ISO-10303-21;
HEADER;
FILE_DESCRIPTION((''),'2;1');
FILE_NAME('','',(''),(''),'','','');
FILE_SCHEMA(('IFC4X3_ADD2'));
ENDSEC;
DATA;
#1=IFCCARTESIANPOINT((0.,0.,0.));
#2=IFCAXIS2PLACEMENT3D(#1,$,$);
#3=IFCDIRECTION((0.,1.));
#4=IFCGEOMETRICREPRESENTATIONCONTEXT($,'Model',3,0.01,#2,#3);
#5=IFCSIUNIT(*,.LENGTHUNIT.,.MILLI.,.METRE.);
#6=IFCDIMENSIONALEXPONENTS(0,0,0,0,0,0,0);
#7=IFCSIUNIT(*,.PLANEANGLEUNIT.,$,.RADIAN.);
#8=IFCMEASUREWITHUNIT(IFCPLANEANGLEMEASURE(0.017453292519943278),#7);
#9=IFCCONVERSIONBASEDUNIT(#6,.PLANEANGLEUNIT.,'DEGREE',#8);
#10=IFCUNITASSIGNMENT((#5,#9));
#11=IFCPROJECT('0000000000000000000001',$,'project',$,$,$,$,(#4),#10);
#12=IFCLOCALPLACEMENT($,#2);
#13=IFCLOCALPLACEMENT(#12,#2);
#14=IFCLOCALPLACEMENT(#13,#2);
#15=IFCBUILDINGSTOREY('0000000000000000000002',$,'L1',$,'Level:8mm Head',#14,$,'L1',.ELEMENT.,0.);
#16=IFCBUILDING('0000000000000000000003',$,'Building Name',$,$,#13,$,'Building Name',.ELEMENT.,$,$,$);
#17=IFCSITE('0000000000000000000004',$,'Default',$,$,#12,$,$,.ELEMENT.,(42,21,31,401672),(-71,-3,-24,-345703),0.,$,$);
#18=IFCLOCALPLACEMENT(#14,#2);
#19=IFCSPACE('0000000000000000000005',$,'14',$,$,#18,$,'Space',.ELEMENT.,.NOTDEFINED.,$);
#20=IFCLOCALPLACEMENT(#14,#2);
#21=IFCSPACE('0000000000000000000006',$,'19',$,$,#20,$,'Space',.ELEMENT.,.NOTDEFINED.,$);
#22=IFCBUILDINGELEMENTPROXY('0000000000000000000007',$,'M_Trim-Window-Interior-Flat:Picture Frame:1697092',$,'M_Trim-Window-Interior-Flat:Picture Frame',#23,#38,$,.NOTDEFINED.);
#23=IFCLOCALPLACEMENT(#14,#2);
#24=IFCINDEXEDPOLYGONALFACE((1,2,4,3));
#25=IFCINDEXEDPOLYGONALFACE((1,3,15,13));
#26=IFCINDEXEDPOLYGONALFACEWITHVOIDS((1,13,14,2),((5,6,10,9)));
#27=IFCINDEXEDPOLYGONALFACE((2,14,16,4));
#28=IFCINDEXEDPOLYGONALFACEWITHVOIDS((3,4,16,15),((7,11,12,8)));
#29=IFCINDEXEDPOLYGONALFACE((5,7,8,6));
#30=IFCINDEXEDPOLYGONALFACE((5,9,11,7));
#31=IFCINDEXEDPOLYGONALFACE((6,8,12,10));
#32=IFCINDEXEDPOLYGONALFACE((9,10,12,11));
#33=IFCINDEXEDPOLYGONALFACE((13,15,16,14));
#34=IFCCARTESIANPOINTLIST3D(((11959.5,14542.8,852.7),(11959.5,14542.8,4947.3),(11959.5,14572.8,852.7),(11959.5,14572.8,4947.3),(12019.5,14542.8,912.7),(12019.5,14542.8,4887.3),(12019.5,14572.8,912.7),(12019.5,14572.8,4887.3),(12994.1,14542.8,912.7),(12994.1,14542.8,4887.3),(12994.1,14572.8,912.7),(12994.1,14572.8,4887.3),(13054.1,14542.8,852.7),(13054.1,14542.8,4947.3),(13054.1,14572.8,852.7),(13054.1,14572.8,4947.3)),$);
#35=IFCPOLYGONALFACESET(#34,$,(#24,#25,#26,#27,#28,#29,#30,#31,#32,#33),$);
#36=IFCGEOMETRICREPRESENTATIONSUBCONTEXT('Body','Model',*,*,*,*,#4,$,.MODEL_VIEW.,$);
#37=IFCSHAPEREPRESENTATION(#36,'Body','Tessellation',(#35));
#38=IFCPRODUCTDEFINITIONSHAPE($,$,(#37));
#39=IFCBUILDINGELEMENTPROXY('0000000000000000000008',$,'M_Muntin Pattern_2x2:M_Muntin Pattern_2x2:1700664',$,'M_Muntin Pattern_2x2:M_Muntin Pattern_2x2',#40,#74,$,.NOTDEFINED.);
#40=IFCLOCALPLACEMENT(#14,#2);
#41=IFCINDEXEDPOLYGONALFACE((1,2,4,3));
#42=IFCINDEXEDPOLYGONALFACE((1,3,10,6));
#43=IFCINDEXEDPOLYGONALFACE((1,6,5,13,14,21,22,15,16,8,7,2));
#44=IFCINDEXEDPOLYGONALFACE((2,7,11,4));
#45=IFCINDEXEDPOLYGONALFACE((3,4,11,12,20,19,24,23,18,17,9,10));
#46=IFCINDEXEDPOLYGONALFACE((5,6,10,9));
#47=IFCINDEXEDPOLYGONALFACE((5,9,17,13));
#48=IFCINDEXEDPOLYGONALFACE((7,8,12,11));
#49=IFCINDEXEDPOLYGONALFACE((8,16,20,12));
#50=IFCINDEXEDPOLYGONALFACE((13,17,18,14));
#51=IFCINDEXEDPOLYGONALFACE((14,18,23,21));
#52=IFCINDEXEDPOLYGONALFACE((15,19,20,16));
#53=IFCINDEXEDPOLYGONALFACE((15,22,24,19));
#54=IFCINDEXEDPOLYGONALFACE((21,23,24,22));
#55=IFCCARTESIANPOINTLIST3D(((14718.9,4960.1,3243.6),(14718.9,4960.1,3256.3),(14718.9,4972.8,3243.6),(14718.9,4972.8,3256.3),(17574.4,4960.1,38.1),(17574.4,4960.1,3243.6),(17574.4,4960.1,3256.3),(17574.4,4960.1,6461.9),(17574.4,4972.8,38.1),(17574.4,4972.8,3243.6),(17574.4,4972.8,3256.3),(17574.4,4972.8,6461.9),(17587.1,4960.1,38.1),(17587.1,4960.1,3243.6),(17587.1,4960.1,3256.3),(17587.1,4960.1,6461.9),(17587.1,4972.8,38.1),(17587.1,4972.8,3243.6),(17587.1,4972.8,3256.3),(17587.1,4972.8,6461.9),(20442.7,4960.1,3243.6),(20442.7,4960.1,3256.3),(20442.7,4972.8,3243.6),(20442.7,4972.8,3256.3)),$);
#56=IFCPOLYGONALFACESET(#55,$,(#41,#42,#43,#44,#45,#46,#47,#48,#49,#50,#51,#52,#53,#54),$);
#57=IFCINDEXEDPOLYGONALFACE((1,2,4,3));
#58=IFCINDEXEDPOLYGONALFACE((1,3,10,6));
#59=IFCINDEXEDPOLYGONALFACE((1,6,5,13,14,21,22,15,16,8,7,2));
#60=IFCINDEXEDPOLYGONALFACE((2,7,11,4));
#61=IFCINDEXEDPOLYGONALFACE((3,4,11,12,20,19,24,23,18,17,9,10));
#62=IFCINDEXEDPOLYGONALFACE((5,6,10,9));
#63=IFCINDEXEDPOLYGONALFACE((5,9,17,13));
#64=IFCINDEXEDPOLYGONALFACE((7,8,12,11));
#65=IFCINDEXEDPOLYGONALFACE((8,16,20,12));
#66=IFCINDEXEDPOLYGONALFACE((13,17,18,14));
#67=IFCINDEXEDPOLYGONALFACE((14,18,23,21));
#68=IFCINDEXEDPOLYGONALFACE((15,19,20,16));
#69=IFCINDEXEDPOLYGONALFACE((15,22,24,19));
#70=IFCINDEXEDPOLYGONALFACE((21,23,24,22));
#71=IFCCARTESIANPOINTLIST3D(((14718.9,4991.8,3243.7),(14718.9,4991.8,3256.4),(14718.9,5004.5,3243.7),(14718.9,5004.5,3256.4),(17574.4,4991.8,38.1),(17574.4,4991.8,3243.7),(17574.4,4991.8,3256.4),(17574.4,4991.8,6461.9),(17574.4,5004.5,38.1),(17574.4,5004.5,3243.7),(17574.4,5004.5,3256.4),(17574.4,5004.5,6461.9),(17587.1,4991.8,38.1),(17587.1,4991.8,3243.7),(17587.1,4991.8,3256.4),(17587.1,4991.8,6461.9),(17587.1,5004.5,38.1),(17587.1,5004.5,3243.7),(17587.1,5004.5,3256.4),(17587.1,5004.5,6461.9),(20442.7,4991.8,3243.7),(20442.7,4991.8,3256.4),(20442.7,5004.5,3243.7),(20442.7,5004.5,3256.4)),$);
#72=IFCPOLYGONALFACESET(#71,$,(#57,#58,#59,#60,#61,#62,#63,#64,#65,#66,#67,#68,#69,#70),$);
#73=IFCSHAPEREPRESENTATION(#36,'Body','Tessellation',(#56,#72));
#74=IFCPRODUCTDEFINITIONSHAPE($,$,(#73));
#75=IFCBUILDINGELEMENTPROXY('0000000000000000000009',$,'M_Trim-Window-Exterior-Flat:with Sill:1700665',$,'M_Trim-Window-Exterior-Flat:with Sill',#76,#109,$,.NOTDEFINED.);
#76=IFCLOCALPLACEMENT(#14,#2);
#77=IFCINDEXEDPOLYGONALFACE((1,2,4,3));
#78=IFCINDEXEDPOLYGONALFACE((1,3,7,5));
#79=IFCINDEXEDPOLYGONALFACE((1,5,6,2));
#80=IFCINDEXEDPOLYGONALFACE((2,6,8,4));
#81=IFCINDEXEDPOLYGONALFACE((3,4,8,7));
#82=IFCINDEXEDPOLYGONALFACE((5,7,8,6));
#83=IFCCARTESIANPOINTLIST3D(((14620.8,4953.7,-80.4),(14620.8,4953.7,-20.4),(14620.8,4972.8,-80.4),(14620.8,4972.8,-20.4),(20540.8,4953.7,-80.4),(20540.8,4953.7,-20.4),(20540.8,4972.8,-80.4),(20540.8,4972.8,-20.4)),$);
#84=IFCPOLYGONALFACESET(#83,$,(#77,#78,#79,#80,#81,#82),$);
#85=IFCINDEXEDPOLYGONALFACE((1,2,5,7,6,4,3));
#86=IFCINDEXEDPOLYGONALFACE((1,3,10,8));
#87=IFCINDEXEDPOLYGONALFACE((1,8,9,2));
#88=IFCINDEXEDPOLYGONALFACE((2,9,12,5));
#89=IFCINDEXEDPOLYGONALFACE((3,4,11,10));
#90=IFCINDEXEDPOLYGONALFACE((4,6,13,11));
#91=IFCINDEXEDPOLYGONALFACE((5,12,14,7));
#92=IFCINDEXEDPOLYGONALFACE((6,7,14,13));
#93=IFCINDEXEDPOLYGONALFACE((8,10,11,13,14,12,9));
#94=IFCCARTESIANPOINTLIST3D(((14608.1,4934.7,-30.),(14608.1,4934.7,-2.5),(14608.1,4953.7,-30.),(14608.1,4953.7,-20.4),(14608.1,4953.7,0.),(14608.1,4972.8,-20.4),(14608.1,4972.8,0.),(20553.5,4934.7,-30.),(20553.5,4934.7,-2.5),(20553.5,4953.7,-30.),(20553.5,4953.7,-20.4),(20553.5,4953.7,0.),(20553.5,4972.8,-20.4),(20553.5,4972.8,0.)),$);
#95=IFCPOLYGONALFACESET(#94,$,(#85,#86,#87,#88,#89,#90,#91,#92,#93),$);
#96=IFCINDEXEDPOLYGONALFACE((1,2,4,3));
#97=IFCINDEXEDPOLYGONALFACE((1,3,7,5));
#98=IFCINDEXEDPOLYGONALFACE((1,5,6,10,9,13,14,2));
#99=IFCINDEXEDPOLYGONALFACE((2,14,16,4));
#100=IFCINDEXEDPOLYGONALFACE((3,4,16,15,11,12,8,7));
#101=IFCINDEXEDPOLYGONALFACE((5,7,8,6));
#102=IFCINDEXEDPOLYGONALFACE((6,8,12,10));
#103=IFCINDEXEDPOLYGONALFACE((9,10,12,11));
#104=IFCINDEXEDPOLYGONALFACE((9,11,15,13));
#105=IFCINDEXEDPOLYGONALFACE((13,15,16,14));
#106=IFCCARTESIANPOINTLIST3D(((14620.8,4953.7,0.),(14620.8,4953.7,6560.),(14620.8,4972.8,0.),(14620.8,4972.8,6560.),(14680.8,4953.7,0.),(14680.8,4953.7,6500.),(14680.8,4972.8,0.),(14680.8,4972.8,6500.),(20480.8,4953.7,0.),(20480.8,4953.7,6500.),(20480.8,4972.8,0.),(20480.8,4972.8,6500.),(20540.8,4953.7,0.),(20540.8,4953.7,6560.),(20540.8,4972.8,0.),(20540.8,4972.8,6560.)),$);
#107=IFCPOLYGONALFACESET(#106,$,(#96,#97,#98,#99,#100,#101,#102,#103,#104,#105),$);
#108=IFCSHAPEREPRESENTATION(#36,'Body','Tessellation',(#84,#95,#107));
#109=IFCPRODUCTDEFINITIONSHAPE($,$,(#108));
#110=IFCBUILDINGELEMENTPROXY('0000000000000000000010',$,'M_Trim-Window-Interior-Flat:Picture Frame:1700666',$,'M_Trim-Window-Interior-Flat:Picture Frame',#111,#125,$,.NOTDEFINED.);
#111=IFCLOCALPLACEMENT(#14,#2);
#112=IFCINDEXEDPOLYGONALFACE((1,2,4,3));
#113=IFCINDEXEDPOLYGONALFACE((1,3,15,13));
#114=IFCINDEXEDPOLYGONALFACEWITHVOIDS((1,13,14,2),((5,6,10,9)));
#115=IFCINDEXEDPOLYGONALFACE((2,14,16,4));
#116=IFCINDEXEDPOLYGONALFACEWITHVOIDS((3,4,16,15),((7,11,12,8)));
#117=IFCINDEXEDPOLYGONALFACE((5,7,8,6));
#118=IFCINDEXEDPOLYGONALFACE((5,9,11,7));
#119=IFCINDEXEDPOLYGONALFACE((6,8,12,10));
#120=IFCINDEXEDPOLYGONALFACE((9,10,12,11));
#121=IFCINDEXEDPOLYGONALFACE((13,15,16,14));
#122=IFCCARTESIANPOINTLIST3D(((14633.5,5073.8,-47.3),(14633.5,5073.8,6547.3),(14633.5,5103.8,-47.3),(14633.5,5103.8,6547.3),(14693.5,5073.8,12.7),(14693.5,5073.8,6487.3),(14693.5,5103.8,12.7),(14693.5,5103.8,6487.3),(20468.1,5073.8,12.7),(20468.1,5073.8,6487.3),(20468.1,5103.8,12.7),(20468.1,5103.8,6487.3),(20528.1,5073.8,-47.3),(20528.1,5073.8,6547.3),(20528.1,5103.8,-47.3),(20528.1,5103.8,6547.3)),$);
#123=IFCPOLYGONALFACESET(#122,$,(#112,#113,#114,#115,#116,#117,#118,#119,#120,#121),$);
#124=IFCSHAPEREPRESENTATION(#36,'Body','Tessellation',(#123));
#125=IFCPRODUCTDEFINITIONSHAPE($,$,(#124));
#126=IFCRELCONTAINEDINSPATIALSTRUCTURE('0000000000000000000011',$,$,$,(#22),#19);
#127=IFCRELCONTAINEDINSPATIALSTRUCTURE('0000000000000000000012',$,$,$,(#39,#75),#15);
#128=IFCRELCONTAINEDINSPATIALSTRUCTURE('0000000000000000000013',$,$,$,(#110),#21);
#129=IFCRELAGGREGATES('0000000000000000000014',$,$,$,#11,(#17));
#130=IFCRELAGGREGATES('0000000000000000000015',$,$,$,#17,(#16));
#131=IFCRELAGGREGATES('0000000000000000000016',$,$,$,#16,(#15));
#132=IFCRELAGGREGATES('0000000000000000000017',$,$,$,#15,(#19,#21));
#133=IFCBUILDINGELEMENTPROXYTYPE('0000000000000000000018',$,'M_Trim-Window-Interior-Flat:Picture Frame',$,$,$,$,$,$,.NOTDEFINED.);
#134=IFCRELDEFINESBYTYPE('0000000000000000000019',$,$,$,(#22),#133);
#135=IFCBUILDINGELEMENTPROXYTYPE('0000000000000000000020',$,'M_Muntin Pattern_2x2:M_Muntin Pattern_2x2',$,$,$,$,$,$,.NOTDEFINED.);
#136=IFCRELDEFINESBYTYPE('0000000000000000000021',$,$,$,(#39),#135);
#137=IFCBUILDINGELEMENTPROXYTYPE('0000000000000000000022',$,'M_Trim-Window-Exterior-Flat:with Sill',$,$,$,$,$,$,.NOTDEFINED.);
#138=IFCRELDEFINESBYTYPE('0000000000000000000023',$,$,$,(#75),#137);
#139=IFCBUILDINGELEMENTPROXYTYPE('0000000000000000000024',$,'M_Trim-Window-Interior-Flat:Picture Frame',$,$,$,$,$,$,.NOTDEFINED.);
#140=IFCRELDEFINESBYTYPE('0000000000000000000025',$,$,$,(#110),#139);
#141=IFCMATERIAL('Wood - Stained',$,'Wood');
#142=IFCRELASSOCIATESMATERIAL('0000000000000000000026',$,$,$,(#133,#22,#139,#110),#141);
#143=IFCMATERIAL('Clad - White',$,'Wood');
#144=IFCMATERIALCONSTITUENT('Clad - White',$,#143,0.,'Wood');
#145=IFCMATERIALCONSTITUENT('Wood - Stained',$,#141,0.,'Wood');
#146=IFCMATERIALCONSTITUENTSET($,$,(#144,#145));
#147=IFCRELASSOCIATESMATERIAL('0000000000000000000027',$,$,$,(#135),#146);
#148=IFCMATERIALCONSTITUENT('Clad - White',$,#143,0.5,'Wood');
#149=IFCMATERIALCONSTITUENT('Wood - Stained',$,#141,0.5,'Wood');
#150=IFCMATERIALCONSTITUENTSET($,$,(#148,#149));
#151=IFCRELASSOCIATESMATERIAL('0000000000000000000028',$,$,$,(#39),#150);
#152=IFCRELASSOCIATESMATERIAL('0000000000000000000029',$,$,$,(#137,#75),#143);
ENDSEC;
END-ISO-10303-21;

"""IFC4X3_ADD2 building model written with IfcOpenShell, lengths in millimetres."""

from ifc_helpers import new_model, entity, si_unit, converted_unit, direction, frame, frame_2d, origin, place, context, subcontext, project, spatial, polyline, rectangle, outline, extrude, source, transform, mapped, material, constituent, constituent_set, type_object, type_shapes, element, save


model = new_model("IFC4X3_ADD2")

# Units and contexts
model_context = context("Model", 3, precision=0.01, world=origin(), true_north=direction((0.0, 1.0)))
body_context = subcontext(model_context, "Body", "Model", "MODEL_VIEW")
ifc_project = project(units=[si_unit("LENGTHUNIT", "METRE", prefix="MILLI"), converted_unit("PLANEANGLEUNIT", "DEGREE", entity("IfcPlaneAngleMeasure", 0.017453292519943278), si_unit("PLANEANGLEUNIT", "RADIAN"), dimensions=[0, 0, 0, 0, 0, 0, 0])], contexts=[model_context])

# Site, building, storey
site_placement = place(None, origin())
site = spatial("IfcSite", under=ifc_project, at=site_placement, Name="Default", CompositionType="ELEMENT", RefLatitude=(42, 21, 31, 401672), RefLongitude=(-71, -3, -24, -345703), RefElevation=0.0)
building_placement = place(site_placement, origin())
building = spatial("IfcBuilding", under=site, at=building_placement, Name="Building Name", LongName="Building Name", CompositionType="ELEMENT")
storey_placement = place(building_placement, origin())
storey = spatial("IfcBuildingStorey", under=building, at=storey_placement, Name="L1", ObjectType="Level:8mm Head", LongName="L1", CompositionType="ELEMENT", Elevation=0.0)

# Shared definitions
ifc_material_1 = material(Name="Clad - White", Category="Wood")
ifc_material_2 = material(Name="Wood - Stained", Category="Wood")

# Shared definitions
building_element_proxy_type_1 = type_object("IfcBuildingElementProxyType", Name="M_Trim-Window-Interior-Flat:Picture Frame", PredefinedType="NOTDEFINED", material=ifc_material_2)
shared_shape_1 = source(origin(), body_context, "Body", "SweptSolid", [
    extrude(outline(polyline([(-547.3, -2047.3), (547.3, -2047.3), (547.3, 2047.3), (-547.3, 2047.3), (-547.3, -2047.3)]), holes=[polyline([(-487.3, -1987.3), (-487.3, 1987.3), (487.3, 1987.3), (487.3, -1987.3), (-487.3, -1987.3)])]), frame((0.0, -2000.0, 0.0), z_axis=(0.0, 0.0, 1.0), x_axis=(-1.0, 0.0, 0.0)), (0.0, 0.0, 1.0), 30.0),
])
type_shapes(building_element_proxy_type_1, [shared_shape_1])

# Shared definitions
space_1_placement = place(storey_placement, origin())
space_1 = spatial("IfcSpace", under=storey, at=space_1_placement, Name="14", LongName="Space", CompositionType="ELEMENT", PredefinedType="NOTDEFINED")

# Building element proxies
proxy_1_placement = place(space_1_placement, frame((12506.8, 14572.8, 4900.0), z_axis=(0.0, -1.0, 0.0), x_axis=(1.0, 0.0, 0.0)))
element("IfcBuildingElementProxy", 1, at=proxy_1_placement, inside=space_1, type_object=building_element_proxy_type_1, material=ifc_material_2, Name="M_Trim-Window-Interior-Flat:Picture Frame:1697092", ObjectType="M_Trim-Window-Interior-Flat:Picture Frame", PredefinedType="NOTDEFINED", context=body_context, shape_type="MappedRepresentation", body=[
    mapped(shared_shape_1, transform((0.0, 0.0, 0.0), scale=1.0)),
])
ifc_constituent_1 = constituent(ifc_material_1, Name="Clad - White", Category="Wood", fraction=0.5)
ifc_constituent_2 = constituent(ifc_material_2, Name="Wood - Stained", Category="Wood", fraction=0.5)
ifc_constituent_set_1 = constituent_set(constituents=[ifc_constituent_1, ifc_constituent_2])
ifc_constituent_3 = constituent(ifc_material_1, Name="Clad - White", Category="Wood", fraction=0.0)
ifc_constituent_4 = constituent(ifc_material_2, Name="Wood - Stained", Category="Wood", fraction=0.0)
ifc_constituent_set_2 = constituent_set(constituents=[ifc_constituent_3, ifc_constituent_4])
building_element_proxy_type_2 = type_object("IfcBuildingElementProxyType", Name="M_Muntin Pattern_2x2:M_Muntin Pattern_2x2", PredefinedType="NOTDEFINED", material=ifc_constituent_set_2)
shared_shape_2 = source(origin(), body_context, "Body", "SweptSolid", [
    extrude(outline(polyline([(6.4, -6.4), (3211.9, -6.4), (3211.9, 6.3), (6.4, 6.3), (6.4, 2861.9), (-6.3, 2861.9), (-6.3, 6.3), (-3211.9, 6.3), (-3211.9, -6.4), (-6.3, -6.4), (-6.3, -2861.9), (6.4, -2861.9), (6.4, -6.4)])), frame((0.0, -22.2, 3211.9), z_axis=(0.0, 1.0, 0.0), x_axis=(0.0, 0.0, 1.0)), (0.0, 0.0, 1.0), 12.7),
    extrude(outline(polyline([(6.4, -6.4), (3211.9, -6.4), (3211.9, 6.3), (6.4, 6.3), (6.4, 2861.9), (-6.3, 2861.9), (-6.3, 6.3), (-3211.9, 6.3), (-3211.9, -6.4), (-6.3, -6.4), (-6.3, -2861.9), (6.4, -2861.9), (6.4, -6.4)])), frame((0.0, 9.5, 3211.9), z_axis=(0.0, 1.0, 0.0), x_axis=(0.0, 0.0, 1.0)), (0.0, 0.0, 1.0), 12.7),
])
type_shapes(building_element_proxy_type_2, [shared_shape_2])
proxy_2_placement = place(storey_placement, frame((17580.8, 4982.3, 38.1)))
element("IfcBuildingElementProxy", 2, at=proxy_2_placement, inside=storey, type_object=building_element_proxy_type_2, material=ifc_constituent_set_1, Name="M_Muntin Pattern_2x2:M_Muntin Pattern_2x2:1700664", ObjectType="M_Muntin Pattern_2x2:M_Muntin Pattern_2x2", PredefinedType="NOTDEFINED", context=body_context, shape_type="MappedRepresentation", body=[
    mapped(shared_shape_2, transform((0.0, 0.0, 0.0), scale=1.0)),
])
building_element_proxy_type_3 = type_object("IfcBuildingElementProxyType", Name="M_Trim-Window-Exterior-Flat:with Sill", PredefinedType="NOTDEFINED", material=ifc_material_1)
shared_shape_3 = source(origin(), body_context, "Body", "SweptSolid", [
    extrude(rectangle(XDim=5920.0, YDim=60.0, at=frame_2d((0.0, 0.0), x_axis=(1.0, 0.0))), frame((0.0, -6550.4, 0.0), z_axis=(0.0, 0.0, 1.0), x_axis=(-1.0, 0.0, 0.0)), (0.0, 0.0, 1.0), 19.0),
    extrude(outline(polyline([(-19.0, -15.2), (0.0, -15.2), (0.0, -5.7), (19.0, -5.7), (19.0, 14.8), (0.0, 14.8), (-19.0, 12.3), (-19.0, -15.2)])), frame((-2972.7, -6514.8, 19.0), z_axis=(1.0, 0.0, 0.0), x_axis=(0.0, 0.0, -1.0)), (0.0, 0.0, 1.0), 5945.4),
    extrude(outline(polyline([(-3295.0, -2960.0), (3265.0, -2960.0), (3265.0, -2900.0), (-3235.0, -2900.0), (-3235.0, 2900.0), (3265.0, 2900.0), (3265.0, 2960.0), (-3295.0, 2960.0), (-3295.0, -2960.0)])), frame((0.0, -3235.0, 0.0), z_axis=(0.0, 0.0, 1.0), x_axis=(0.0, -1.0, 0.0)), (0.0, 0.0, 1.0), 19.0),
])
type_shapes(building_element_proxy_type_3, [shared_shape_3])
proxy_3_placement = place(storey_placement, frame((17580.8, 4972.8, 6500.0), z_axis=(0.0, -1.0, 0.0), x_axis=(1.0, 0.0, 0.0)))
element("IfcBuildingElementProxy", 3, at=proxy_3_placement, inside=storey, type_object=building_element_proxy_type_3, material=ifc_material_1, Name="M_Trim-Window-Exterior-Flat:with Sill:1700665", ObjectType="M_Trim-Window-Exterior-Flat:with Sill", PredefinedType="NOTDEFINED", context=body_context, shape_type="MappedRepresentation", body=[
    mapped(shared_shape_3, transform((0.0, 0.0, 0.0), scale=1.0)),
])

# Shared definitions
space_2_placement = place(storey_placement, origin())
space_2 = spatial("IfcSpace", under=storey, at=space_2_placement, Name="19", LongName="Space", CompositionType="ELEMENT", PredefinedType="NOTDEFINED")

# Building element proxy
building_element_proxy_type_4 = type_object("IfcBuildingElementProxyType", Name="M_Trim-Window-Interior-Flat:Picture Frame", PredefinedType="NOTDEFINED", material=ifc_material_2)
shared_shape_4 = source(origin(), body_context, "Body", "SweptSolid", [
    extrude(outline(polyline([(-2947.3, -3297.3), (2947.3, -3297.3), (2947.3, 3297.3), (-2947.3, 3297.3), (-2947.3, -3297.3)]), holes=[polyline([(-2887.3, -3237.3), (-2887.3, 3237.3), (2887.3, 3237.3), (2887.3, -3237.3), (-2887.3, -3237.3)])]), frame((0.0, -3250.0, 0.0), z_axis=(0.0, 0.0, 1.0), x_axis=(-1.0, 0.0, 0.0)), (0.0, 0.0, 1.0), 30.0),
])
type_shapes(building_element_proxy_type_4, [shared_shape_4])
proxy_4_placement = place(space_2_placement, frame((17580.8, 5073.8, 6500.0), z_axis=(0.0, 1.0, 0.0), x_axis=(-1.0, 0.0, 0.0)))
element("IfcBuildingElementProxy", 4, at=proxy_4_placement, inside=space_2, type_object=building_element_proxy_type_4, material=ifc_material_2, Name="M_Trim-Window-Interior-Flat:Picture Frame:1700666", ObjectType="M_Trim-Window-Interior-Flat:Picture Frame", PredefinedType="NOTDEFINED", context=body_context, shape_type="MappedRepresentation", body=[
    mapped(shared_shape_4, transform((0.0, 0.0, 0.0), scale=1.0)),
])

save(model, "model.ifc")
